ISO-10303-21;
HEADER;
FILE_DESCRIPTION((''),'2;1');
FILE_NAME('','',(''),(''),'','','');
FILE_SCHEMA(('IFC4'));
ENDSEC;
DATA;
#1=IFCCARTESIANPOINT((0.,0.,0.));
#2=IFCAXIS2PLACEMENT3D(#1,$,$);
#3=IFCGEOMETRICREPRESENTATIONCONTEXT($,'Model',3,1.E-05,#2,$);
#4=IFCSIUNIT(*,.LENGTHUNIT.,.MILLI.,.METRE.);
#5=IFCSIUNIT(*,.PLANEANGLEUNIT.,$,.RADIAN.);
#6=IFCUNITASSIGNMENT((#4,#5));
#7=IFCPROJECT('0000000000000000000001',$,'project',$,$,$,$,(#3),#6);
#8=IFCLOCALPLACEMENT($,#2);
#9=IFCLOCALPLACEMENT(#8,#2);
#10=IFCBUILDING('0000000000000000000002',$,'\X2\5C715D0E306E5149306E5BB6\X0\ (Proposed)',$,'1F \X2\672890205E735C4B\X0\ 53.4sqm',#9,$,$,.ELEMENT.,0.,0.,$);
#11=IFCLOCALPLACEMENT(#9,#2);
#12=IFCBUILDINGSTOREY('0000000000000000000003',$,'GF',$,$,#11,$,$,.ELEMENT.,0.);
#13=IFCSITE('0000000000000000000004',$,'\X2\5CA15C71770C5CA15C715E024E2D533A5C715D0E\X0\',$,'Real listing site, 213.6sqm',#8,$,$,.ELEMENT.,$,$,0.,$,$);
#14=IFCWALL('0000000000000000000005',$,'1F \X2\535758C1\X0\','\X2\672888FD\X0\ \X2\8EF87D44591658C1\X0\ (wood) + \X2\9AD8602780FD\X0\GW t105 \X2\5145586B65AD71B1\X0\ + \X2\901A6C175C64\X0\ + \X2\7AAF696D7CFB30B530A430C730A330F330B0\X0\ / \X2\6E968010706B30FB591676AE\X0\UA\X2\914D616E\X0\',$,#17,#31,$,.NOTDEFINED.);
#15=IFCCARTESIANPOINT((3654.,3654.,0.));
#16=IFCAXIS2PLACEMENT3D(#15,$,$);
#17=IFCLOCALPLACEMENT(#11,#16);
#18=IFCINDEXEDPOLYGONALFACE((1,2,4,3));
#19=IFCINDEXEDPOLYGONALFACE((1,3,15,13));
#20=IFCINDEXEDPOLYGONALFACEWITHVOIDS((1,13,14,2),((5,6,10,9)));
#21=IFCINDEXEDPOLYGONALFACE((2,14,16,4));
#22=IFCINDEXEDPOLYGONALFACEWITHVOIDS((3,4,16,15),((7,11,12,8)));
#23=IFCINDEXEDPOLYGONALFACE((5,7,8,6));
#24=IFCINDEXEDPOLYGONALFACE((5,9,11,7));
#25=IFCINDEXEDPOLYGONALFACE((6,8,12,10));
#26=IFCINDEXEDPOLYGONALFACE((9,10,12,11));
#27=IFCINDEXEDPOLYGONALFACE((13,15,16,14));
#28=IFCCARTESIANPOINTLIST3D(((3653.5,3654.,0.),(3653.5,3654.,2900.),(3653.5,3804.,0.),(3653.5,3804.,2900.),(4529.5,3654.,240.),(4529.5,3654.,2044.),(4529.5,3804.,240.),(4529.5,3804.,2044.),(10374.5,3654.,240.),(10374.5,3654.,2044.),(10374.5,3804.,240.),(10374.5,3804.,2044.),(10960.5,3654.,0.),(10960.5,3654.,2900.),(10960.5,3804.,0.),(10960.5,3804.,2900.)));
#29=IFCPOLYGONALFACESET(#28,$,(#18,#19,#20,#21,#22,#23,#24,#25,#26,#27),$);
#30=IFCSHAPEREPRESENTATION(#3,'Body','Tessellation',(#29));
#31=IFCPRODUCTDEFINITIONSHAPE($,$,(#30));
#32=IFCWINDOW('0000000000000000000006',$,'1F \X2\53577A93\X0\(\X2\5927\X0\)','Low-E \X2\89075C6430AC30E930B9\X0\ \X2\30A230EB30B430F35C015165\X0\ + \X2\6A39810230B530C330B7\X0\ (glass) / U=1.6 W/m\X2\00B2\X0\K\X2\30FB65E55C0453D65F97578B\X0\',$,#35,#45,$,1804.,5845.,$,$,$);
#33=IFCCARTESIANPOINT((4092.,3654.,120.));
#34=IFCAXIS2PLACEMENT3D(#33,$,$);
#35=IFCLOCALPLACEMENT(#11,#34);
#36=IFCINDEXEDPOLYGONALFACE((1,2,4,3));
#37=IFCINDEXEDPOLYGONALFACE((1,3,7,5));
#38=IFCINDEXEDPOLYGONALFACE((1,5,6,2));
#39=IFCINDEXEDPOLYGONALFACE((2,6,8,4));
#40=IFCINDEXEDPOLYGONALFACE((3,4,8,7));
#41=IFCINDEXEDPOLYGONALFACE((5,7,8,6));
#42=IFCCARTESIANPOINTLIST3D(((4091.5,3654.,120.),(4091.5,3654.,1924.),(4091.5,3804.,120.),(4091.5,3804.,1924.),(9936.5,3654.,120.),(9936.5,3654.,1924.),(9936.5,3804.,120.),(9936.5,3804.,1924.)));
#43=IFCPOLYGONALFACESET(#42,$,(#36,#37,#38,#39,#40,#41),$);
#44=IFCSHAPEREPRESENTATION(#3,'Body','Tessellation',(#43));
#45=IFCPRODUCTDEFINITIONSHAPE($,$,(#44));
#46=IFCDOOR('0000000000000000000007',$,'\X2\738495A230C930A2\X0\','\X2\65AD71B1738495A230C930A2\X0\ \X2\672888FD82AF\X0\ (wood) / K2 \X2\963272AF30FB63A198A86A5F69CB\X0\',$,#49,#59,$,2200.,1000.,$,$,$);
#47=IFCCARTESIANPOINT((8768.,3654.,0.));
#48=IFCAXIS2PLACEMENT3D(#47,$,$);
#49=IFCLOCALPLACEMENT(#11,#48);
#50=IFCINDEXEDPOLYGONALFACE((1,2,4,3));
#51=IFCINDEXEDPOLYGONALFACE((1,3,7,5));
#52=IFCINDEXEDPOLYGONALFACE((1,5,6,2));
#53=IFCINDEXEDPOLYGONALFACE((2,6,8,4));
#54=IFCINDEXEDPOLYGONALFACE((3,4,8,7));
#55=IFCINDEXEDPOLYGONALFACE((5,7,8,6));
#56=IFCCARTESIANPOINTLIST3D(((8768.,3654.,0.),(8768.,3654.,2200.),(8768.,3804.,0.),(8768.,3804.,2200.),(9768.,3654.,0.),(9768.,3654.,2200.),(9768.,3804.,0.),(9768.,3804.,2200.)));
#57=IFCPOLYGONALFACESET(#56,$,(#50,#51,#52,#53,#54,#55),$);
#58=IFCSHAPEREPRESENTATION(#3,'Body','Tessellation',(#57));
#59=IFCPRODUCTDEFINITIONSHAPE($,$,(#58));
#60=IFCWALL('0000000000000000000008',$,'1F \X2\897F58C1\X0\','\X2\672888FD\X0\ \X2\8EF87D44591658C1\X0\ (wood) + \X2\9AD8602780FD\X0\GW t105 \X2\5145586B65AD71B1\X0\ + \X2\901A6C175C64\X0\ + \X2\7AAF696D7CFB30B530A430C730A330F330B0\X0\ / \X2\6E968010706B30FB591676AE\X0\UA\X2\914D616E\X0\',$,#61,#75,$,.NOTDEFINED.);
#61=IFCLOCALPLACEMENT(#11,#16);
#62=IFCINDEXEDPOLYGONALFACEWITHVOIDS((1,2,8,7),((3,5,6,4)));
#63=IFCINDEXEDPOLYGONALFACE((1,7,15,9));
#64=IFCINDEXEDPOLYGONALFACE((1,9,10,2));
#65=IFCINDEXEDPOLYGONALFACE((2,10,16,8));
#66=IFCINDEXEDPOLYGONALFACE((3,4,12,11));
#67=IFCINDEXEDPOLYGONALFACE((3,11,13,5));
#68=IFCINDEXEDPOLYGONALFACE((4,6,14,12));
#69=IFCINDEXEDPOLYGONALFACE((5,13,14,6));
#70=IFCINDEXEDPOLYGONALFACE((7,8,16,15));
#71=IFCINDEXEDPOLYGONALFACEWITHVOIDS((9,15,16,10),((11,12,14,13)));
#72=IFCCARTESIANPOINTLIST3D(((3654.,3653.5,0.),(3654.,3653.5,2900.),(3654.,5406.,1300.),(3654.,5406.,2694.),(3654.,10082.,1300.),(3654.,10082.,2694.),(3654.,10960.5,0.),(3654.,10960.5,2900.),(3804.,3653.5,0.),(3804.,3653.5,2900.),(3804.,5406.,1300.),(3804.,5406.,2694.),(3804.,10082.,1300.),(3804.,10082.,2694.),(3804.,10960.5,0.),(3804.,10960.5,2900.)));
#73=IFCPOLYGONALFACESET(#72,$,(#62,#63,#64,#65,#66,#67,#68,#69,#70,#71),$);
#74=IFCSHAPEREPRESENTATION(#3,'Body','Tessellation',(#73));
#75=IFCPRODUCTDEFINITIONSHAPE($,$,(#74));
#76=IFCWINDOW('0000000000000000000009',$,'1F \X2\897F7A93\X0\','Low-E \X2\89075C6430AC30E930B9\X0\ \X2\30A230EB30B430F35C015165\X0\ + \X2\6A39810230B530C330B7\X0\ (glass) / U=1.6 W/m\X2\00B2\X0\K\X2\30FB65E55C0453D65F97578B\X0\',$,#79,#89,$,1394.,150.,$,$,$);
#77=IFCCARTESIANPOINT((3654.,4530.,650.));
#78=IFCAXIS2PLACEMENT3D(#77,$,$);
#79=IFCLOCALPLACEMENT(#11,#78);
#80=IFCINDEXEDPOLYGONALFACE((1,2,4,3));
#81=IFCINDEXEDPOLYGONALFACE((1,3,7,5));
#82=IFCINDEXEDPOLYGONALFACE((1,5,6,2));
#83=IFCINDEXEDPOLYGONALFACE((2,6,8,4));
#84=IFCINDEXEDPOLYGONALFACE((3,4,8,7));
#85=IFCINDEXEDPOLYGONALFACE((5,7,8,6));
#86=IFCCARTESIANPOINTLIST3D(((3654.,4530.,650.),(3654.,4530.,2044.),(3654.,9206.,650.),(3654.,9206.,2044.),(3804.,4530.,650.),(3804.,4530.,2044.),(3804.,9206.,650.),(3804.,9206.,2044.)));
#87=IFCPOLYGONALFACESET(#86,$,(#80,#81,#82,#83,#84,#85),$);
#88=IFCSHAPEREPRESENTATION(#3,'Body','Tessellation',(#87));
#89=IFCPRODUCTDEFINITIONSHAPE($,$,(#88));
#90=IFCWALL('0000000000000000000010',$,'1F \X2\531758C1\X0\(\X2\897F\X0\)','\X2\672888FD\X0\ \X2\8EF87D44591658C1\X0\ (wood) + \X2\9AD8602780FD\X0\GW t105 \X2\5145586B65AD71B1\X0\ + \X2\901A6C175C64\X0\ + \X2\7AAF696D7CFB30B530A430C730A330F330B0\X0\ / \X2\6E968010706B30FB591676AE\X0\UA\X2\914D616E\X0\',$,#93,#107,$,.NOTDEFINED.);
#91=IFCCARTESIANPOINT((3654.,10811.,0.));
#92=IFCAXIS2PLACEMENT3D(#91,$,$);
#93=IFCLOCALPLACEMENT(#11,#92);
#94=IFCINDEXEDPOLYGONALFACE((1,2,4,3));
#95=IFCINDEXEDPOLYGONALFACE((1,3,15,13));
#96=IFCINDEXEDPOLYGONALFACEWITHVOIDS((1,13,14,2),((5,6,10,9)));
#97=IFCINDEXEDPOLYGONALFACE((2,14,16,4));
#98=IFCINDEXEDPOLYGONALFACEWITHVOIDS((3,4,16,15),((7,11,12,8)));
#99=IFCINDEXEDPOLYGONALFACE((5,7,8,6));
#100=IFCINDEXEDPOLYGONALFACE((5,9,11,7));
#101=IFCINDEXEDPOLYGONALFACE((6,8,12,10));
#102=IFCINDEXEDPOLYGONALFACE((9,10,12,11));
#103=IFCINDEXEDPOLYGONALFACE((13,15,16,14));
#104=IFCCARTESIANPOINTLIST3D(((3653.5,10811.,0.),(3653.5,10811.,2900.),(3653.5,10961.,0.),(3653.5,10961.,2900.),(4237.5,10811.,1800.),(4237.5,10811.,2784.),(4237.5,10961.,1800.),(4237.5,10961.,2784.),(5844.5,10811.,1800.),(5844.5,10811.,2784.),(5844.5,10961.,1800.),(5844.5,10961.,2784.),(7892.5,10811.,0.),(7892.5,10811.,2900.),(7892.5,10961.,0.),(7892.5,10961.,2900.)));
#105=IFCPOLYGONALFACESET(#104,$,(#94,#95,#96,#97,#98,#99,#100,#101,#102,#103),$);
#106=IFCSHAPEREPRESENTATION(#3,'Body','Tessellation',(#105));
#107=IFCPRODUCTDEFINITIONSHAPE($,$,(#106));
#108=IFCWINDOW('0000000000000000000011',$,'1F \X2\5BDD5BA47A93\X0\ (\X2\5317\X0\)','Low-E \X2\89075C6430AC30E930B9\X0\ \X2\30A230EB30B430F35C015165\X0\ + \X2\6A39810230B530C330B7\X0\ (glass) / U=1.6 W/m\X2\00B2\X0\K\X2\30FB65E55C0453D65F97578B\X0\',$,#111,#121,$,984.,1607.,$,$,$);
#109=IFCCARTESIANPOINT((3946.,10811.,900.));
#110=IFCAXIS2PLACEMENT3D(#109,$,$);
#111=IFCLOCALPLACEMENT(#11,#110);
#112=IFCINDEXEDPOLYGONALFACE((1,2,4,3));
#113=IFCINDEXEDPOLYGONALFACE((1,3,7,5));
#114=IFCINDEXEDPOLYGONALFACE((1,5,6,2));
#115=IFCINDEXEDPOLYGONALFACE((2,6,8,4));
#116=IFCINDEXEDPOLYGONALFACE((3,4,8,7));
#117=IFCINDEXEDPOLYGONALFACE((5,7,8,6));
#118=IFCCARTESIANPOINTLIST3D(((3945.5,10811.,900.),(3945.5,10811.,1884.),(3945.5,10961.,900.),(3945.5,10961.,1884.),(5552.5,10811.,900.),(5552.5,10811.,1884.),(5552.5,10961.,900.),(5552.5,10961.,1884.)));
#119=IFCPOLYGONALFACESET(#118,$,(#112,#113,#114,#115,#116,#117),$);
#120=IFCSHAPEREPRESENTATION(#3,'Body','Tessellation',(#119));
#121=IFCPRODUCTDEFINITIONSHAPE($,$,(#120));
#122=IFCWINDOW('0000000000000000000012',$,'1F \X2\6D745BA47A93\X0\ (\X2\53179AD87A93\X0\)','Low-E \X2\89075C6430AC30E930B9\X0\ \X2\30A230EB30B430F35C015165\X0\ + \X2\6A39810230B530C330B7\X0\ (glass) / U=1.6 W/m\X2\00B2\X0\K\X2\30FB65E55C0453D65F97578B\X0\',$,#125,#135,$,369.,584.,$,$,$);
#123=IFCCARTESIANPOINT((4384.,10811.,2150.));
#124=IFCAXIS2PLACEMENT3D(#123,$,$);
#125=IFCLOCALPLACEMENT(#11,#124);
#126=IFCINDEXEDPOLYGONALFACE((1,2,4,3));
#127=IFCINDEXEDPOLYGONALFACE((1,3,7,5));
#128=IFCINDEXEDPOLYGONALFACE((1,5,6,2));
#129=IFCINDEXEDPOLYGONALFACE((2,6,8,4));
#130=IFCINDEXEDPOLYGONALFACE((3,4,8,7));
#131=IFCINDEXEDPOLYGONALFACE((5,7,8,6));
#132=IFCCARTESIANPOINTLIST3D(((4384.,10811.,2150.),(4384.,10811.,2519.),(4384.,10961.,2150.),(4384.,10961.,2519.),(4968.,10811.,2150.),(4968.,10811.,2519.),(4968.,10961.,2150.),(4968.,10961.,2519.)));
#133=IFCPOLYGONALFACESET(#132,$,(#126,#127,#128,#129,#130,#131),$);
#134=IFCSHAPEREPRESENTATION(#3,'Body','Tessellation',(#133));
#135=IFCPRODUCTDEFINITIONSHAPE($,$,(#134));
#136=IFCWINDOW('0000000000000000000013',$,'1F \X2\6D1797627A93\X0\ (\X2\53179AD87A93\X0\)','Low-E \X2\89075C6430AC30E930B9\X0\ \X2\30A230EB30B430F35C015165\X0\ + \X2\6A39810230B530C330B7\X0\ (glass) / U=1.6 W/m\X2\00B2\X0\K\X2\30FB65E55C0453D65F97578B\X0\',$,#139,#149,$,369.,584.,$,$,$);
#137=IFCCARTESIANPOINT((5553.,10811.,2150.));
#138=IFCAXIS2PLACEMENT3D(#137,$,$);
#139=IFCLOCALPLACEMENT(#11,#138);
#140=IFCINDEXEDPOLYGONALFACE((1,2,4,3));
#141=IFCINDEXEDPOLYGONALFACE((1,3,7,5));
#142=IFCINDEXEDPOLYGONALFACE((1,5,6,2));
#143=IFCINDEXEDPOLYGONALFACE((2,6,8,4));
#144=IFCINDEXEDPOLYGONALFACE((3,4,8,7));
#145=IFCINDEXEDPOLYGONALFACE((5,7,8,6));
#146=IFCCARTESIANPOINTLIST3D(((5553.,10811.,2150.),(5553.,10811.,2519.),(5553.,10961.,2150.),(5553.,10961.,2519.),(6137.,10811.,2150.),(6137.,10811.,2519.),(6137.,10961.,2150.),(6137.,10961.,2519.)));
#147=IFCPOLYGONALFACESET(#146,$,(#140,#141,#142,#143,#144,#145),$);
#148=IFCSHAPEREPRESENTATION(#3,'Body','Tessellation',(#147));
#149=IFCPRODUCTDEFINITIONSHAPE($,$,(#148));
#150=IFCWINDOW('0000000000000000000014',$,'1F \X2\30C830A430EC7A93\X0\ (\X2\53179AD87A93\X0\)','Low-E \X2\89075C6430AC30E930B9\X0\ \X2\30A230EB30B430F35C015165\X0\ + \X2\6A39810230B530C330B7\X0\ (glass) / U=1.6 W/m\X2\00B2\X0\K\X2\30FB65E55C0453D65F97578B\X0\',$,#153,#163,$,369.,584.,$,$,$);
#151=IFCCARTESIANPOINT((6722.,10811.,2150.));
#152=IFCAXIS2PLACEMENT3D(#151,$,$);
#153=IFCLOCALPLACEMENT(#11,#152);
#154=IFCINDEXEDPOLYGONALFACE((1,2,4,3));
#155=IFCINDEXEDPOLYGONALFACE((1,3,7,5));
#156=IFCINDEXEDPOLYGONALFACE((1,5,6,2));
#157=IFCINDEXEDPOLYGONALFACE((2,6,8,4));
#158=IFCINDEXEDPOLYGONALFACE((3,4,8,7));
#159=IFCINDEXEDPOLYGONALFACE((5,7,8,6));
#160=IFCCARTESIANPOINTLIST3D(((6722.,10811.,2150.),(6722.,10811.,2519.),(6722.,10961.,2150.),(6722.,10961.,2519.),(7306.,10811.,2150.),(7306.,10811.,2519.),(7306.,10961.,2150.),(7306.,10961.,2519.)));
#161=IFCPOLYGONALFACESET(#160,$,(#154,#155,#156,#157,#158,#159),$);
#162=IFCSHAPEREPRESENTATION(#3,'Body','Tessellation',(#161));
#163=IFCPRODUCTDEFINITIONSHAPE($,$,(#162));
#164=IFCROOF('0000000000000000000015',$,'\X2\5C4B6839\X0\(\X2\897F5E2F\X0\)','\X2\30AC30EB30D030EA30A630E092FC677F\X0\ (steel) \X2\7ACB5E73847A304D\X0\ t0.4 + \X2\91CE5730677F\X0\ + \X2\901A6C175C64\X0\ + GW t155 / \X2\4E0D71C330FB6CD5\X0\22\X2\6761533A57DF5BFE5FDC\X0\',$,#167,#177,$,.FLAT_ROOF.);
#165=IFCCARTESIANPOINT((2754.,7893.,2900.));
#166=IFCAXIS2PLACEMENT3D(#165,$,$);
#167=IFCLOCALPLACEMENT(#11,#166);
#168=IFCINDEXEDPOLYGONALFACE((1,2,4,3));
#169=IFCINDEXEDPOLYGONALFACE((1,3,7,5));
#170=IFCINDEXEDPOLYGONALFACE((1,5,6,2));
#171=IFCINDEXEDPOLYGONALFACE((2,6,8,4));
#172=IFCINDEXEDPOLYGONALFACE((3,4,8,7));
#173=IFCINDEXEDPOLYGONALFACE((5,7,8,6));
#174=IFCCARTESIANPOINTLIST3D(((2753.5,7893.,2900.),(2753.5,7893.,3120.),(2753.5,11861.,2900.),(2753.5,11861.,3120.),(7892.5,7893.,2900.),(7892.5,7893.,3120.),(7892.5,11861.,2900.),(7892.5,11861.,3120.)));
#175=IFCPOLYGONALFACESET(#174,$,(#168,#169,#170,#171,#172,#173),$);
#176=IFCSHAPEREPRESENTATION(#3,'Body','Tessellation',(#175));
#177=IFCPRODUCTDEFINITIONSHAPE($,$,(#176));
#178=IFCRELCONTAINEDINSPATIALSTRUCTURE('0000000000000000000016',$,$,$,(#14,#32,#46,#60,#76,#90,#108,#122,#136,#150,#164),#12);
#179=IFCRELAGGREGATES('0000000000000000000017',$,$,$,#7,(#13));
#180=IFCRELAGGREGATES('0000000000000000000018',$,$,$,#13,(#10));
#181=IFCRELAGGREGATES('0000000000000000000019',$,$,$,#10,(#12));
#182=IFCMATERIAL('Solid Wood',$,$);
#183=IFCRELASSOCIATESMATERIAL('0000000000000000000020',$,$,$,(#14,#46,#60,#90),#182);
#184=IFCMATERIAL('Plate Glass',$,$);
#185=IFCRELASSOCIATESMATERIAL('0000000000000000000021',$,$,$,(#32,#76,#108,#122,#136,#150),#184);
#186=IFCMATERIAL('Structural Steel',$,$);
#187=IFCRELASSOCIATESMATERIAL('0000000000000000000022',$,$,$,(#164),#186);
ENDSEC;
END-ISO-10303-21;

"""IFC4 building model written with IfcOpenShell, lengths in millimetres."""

from ifc_helpers import new_model, si_unit, frame, frame_2d, origin, place, context, project, spatial, rectangle, extrude, material, element, fill, save


model = new_model("IFC4")

# Units and contexts
model_context = context("Model", 3, precision=1e-05, world=origin())
ifc_project = project(units=[si_unit("LENGTHUNIT", "METRE", prefix="MILLI"), si_unit("PLANEANGLEUNIT", "RADIAN")], contexts=[model_context])

# Site, building, storey
site_placement = place(None, origin())
site = spatial("IfcSite", under=ifc_project, at=site_placement, Name="岡山県岡山市中区山崎", ObjectType="Real listing site, 213.6sqm", CompositionType="ELEMENT", RefElevation=0.0)
building_placement = place(site_placement, origin())
building = spatial("IfcBuilding", under=site, at=building_placement, Name="山崎の光の家 (Proposed)", ObjectType="1F 木造平屋 53.4sqm", CompositionType="ELEMENT", ElevationOfRefHeight=0.0, ElevationOfTerrain=0.0)
storey_placement = place(building_placement, origin())
storey = spatial("IfcBuildingStorey", under=building, at=storey_placement, Name="GF", CompositionType="ELEMENT", Elevation=0.0)

# Shared definitions
ifc_material_1 = material(Name="Solid Wood")

# Wall, openings, window, door
wall_1_placement = place(storey_placement, frame((3654.0, 3654.0, 0.0)))
wall_1 = element("IfcWall", 1, at=wall_1_placement, inside=storey, material=ifc_material_1, Name="1F 南壁", Description="木製 軸組外壁 (wood) + 高性能GW t105 充填断熱 + 通気層 + 窯業系サイディング / 準耐火・外皮UA配慮", PredefinedType="NOTDEFINED", context=model_context, shape_type="SweptSolid", body=[
    extrude(rectangle(XDim=7307.0, YDim=150.0, at=frame_2d((3653.0, 75.0))), frame((3654.0, 3654.0, 0.0)), (0.0, 0.0, 1.0), 2900.0),
])
opening_1_placement = place(storey_placement, frame((4092.0, 3654.0, 120.0)))
opening_1 = element("IfcOpeningElement", 2, at=opening_1_placement, cuts=wall_1, PredefinedType="NOTDEFINED", context=model_context, shape_type="SweptSolid", body=[
    extrude(rectangle(XDim=5845.0, YDim=150.0, at=frame_2d((2922.0, 75.0))), frame((4092.0, 3654.0, 120.0)), (0.0, 0.0, 1.0), 1804.0),
])
opening_2_placement = place(storey_placement, frame((8768.0, 3654.0, 0.0)))
opening_2 = element("IfcOpeningElement", 3, at=opening_2_placement, cuts=wall_1, PredefinedType="NOTDEFINED", context=model_context, shape_type="SweptSolid", body=[
    extrude(rectangle(XDim=1000.0, YDim=150.0, at=frame_2d((500.0, 75.0))), frame((8768.0, 3654.0, 0.0)), (0.0, 0.0, 1.0), 2200.0),
])
ifc_material_2 = material(Name="Plate Glass")
window_1_placement = place(storey_placement, frame((4092.0, 3654.0, 120.0)))
window_1 = element("IfcWindow", 4, at=window_1_placement, inside=storey, material=ifc_material_2, Name="1F 南窓(大)", Description="Low-E 複層ガラス アルゴン封入 + 樹脂サッシ (glass) / U=1.6 W/m²K・日射取得型", OverallHeight=1804.0, OverallWidth=5845.0, context=model_context, shape_type="SweptSolid", body=[
    extrude(rectangle(XDim=5845.0, YDim=150.0, at=frame_2d((2922.0, 75.0))), frame((4092.0, 3654.0, 120.0)), (0.0, 0.0, 1.0), 1804.0),
])
fill(opening_1, window_1)
door_placement = place(storey_placement, frame((8768.0, 3654.0, 0.0)))
door = element("IfcDoor", 5, at=door_placement, inside=storey, material=ifc_material_1, Name="玄関ドア", Description="断熱玄関ドア 木製芯 (wood) / K2 防犯・採風機構", OverallHeight=2200.0, OverallWidth=1000.0, context=model_context, shape_type="SweptSolid", body=[
    extrude(rectangle(XDim=1000.0, YDim=150.0, at=frame_2d((500.0, 75.0))), frame((8768.0, 3654.0, 0.0)), (0.0, 0.0, 1.0), 2200.0),
])
fill(opening_2, door)

# Wall, opening, window
wall_2_placement = place(storey_placement, frame((3654.0, 3654.0, 0.0)))
wall_2 = element("IfcWall", 6, at=wall_2_placement, inside=storey, material=ifc_material_1, Name="1F 西壁", Description="木製 軸組外壁 (wood) + 高性能GW t105 充填断熱 + 通気層 + 窯業系サイディング / 準耐火・外皮UA配慮", PredefinedType="NOTDEFINED", context=model_context, shape_type="SweptSolid", body=[
    extrude(rectangle(XDim=150.0, YDim=7307.0, at=frame_2d((75.0, 3653.0))), frame((3654.0, 3654.0, 0.0)), (0.0, 0.0, 1.0), 2900.0),
])
opening_3_placement = place(storey_placement, frame((3654.0, 4530.0, 650.0)))
opening_3 = element("IfcOpeningElement", 7, at=opening_3_placement, cuts=wall_2, PredefinedType="NOTDEFINED", context=model_context, shape_type="SweptSolid", body=[
    extrude(rectangle(XDim=150.0, YDim=4676.0, at=frame_2d((75.0, 2338.0))), frame((3654.0, 4530.0, 650.0)), (0.0, 0.0, 1.0), 1394.0),
])
window_2_placement = place(storey_placement, frame((3654.0, 4530.0, 650.0)))
window_2 = element("IfcWindow", 8, at=window_2_placement, inside=storey, material=ifc_material_2, Name="1F 西窓", Description="Low-E 複層ガラス アルゴン封入 + 樹脂サッシ (glass) / U=1.6 W/m²K・日射取得型", OverallHeight=1394.0, OverallWidth=150.0, context=model_context, shape_type="SweptSolid", body=[
    extrude(rectangle(XDim=150.0, YDim=4676.0, at=frame_2d((75.0, 2338.0))), frame((3654.0, 4530.0, 650.0)), (0.0, 0.0, 1.0), 1394.0),
])
fill(opening_3, window_2)

# Wall, openings, windows
wall_3_placement = place(storey_placement, frame((3654.0, 10811.0, 0.0)))
wall_3 = element("IfcWall", 9, at=wall_3_placement, inside=storey, material=ifc_material_1, Name="1F 北壁(西)", Description="木製 軸組外壁 (wood) + 高性能GW t105 充填断熱 + 通気層 + 窯業系サイディング / 準耐火・外皮UA配慮", PredefinedType="NOTDEFINED", context=model_context, shape_type="SweptSolid", body=[
    extrude(rectangle(XDim=4239.0, YDim=150.0, at=frame_2d((2119.0, 75.0))), frame((3654.0, 10811.0, 0.0)), (0.0, 0.0, 1.0), 2900.0),
])
opening_4_placement = place(storey_placement, frame((3946.0, 10811.0, 900.0)))
opening_4 = element("IfcOpeningElement", 10, at=opening_4_placement, cuts=wall_3, PredefinedType="NOTDEFINED", context=model_context, shape_type="SweptSolid", body=[
    extrude(rectangle(XDim=1607.0, YDim=150.0, at=frame_2d((803.0, 75.0))), frame((3946.0, 10811.0, 900.0)), (0.0, 0.0, 1.0), 984.0),
])
opening_5_placement = place(storey_placement, frame((4384.0, 10811.0, 2150.0)))
opening_5 = element("IfcOpeningElement", 11, at=opening_5_placement, cuts=wall_3, PredefinedType="NOTDEFINED", context=model_context, shape_type="SweptSolid", body=[
    extrude(rectangle(XDim=584.0, YDim=150.0, at=frame_2d((292.0, 75.0))), frame((4384.0, 10811.0, 2150.0)), (0.0, 0.0, 1.0), 369.0),
])
opening_6_placement = place(storey_placement, frame((5553.0, 10811.0, 2150.0)))
opening_6 = element("IfcOpeningElement", 12, at=opening_6_placement, cuts=wall_3, PredefinedType="NOTDEFINED", context=model_context, shape_type="SweptSolid", body=[
    extrude(rectangle(XDim=584.0, YDim=150.0, at=frame_2d((292.0, 75.0))), frame((5553.0, 10811.0, 2150.0)), (0.0, 0.0, 1.0), 369.0),
])
opening_7_placement = place(storey_placement, frame((6722.0, 10811.0, 2150.0)))
opening_7 = element("IfcOpeningElement", 13, at=opening_7_placement, cuts=wall_3, PredefinedType="NOTDEFINED", context=model_context, shape_type="SweptSolid", body=[
    extrude(rectangle(XDim=584.0, YDim=150.0, at=frame_2d((292.0, 75.0))), frame((6722.0, 10811.0, 2150.0)), (0.0, 0.0, 1.0), 369.0),
])
window_3_placement = place(storey_placement, frame((3946.0, 10811.0, 900.0)))
window_3 = element("IfcWindow", 14, at=window_3_placement, inside=storey, material=ifc_material_2, Name="1F 寝室窓 (北)", Description="Low-E 複層ガラス アルゴン封入 + 樹脂サッシ (glass) / U=1.6 W/m²K・日射取得型", OverallHeight=984.0, OverallWidth=1607.0, context=model_context, shape_type="SweptSolid", body=[
    extrude(rectangle(XDim=1607.0, YDim=150.0, at=frame_2d((803.0, 75.0))), frame((3946.0, 10811.0, 900.0)), (0.0, 0.0, 1.0), 984.0),
])
fill(opening_4, window_3)
window_4_placement = place(storey_placement, frame((4384.0, 10811.0, 2150.0)))
window_4 = element("IfcWindow", 15, at=window_4_placement, inside=storey, material=ifc_material_2, Name="1F 浴室窓 (北高窓)", Description="Low-E 複層ガラス アルゴン封入 + 樹脂サッシ (glass) / U=1.6 W/m²K・日射取得型", OverallHeight=369.0, OverallWidth=584.0, context=model_context, shape_type="SweptSolid", body=[
    extrude(rectangle(XDim=584.0, YDim=150.0, at=frame_2d((292.0, 75.0))), frame((4384.0, 10811.0, 2150.0)), (0.0, 0.0, 1.0), 369.0),
])
fill(opening_5, window_4)
window_5_placement = place(storey_placement, frame((5553.0, 10811.0, 2150.0)))
window_5 = element("IfcWindow", 16, at=window_5_placement, inside=storey, material=ifc_material_2, Name="1F 洗面窓 (北高窓)", Description="Low-E 複層ガラス アルゴン封入 + 樹脂サッシ (glass) / U=1.6 W/m²K・日射取得型", OverallHeight=369.0, OverallWidth=584.0, context=model_context, shape_type="SweptSolid", body=[
    extrude(rectangle(XDim=584.0, YDim=150.0, at=frame_2d((292.0, 75.0))), frame((5553.0, 10811.0, 2150.0)), (0.0, 0.0, 1.0), 369.0),
])
fill(opening_6, window_5)
window_6_placement = place(storey_placement, frame((6722.0, 10811.0, 2150.0)))
window_6 = element("IfcWindow", 17, at=window_6_placement, inside=storey, material=ifc_material_2, Name="1F トイレ窓 (北高窓)", Description="Low-E 複層ガラス アルゴン封入 + 樹脂サッシ (glass) / U=1.6 W/m²K・日射取得型", OverallHeight=369.0, OverallWidth=584.0, context=model_context, shape_type="SweptSolid", body=[
    extrude(rectangle(XDim=584.0, YDim=150.0, at=frame_2d((292.0, 75.0))), frame((6722.0, 10811.0, 2150.0)), (0.0, 0.0, 1.0), 369.0),
])
fill(opening_7, window_6)

# Roof
ifc_material_3 = material(Name="Structural Steel")
roof_1_placement = place(storey_placement, frame((2754.0, 7893.0, 2900.0)))
element("IfcRoof", 18, at=roof_1_placement, inside=storey, material=ifc_material_3, Name="屋根(西帯)", Description="ガルバリウム鋼板 (steel) 立平葺き t0.4 + 野地板 + 通気層 + GW t155 / 不燃・法22条区域対応", PredefinedType="FLAT_ROOF", context=model_context, shape_type="SweptSolid", body=[
    extrude(rectangle(XDim=5139.0, YDim=3968.0, at=frame_2d((2569.0, 1984.0))), frame((2754.0, 7893.0, 2900.0)), (0.0, 0.0, 1.0), 220.0),
])

save(model, "model.ifc")
